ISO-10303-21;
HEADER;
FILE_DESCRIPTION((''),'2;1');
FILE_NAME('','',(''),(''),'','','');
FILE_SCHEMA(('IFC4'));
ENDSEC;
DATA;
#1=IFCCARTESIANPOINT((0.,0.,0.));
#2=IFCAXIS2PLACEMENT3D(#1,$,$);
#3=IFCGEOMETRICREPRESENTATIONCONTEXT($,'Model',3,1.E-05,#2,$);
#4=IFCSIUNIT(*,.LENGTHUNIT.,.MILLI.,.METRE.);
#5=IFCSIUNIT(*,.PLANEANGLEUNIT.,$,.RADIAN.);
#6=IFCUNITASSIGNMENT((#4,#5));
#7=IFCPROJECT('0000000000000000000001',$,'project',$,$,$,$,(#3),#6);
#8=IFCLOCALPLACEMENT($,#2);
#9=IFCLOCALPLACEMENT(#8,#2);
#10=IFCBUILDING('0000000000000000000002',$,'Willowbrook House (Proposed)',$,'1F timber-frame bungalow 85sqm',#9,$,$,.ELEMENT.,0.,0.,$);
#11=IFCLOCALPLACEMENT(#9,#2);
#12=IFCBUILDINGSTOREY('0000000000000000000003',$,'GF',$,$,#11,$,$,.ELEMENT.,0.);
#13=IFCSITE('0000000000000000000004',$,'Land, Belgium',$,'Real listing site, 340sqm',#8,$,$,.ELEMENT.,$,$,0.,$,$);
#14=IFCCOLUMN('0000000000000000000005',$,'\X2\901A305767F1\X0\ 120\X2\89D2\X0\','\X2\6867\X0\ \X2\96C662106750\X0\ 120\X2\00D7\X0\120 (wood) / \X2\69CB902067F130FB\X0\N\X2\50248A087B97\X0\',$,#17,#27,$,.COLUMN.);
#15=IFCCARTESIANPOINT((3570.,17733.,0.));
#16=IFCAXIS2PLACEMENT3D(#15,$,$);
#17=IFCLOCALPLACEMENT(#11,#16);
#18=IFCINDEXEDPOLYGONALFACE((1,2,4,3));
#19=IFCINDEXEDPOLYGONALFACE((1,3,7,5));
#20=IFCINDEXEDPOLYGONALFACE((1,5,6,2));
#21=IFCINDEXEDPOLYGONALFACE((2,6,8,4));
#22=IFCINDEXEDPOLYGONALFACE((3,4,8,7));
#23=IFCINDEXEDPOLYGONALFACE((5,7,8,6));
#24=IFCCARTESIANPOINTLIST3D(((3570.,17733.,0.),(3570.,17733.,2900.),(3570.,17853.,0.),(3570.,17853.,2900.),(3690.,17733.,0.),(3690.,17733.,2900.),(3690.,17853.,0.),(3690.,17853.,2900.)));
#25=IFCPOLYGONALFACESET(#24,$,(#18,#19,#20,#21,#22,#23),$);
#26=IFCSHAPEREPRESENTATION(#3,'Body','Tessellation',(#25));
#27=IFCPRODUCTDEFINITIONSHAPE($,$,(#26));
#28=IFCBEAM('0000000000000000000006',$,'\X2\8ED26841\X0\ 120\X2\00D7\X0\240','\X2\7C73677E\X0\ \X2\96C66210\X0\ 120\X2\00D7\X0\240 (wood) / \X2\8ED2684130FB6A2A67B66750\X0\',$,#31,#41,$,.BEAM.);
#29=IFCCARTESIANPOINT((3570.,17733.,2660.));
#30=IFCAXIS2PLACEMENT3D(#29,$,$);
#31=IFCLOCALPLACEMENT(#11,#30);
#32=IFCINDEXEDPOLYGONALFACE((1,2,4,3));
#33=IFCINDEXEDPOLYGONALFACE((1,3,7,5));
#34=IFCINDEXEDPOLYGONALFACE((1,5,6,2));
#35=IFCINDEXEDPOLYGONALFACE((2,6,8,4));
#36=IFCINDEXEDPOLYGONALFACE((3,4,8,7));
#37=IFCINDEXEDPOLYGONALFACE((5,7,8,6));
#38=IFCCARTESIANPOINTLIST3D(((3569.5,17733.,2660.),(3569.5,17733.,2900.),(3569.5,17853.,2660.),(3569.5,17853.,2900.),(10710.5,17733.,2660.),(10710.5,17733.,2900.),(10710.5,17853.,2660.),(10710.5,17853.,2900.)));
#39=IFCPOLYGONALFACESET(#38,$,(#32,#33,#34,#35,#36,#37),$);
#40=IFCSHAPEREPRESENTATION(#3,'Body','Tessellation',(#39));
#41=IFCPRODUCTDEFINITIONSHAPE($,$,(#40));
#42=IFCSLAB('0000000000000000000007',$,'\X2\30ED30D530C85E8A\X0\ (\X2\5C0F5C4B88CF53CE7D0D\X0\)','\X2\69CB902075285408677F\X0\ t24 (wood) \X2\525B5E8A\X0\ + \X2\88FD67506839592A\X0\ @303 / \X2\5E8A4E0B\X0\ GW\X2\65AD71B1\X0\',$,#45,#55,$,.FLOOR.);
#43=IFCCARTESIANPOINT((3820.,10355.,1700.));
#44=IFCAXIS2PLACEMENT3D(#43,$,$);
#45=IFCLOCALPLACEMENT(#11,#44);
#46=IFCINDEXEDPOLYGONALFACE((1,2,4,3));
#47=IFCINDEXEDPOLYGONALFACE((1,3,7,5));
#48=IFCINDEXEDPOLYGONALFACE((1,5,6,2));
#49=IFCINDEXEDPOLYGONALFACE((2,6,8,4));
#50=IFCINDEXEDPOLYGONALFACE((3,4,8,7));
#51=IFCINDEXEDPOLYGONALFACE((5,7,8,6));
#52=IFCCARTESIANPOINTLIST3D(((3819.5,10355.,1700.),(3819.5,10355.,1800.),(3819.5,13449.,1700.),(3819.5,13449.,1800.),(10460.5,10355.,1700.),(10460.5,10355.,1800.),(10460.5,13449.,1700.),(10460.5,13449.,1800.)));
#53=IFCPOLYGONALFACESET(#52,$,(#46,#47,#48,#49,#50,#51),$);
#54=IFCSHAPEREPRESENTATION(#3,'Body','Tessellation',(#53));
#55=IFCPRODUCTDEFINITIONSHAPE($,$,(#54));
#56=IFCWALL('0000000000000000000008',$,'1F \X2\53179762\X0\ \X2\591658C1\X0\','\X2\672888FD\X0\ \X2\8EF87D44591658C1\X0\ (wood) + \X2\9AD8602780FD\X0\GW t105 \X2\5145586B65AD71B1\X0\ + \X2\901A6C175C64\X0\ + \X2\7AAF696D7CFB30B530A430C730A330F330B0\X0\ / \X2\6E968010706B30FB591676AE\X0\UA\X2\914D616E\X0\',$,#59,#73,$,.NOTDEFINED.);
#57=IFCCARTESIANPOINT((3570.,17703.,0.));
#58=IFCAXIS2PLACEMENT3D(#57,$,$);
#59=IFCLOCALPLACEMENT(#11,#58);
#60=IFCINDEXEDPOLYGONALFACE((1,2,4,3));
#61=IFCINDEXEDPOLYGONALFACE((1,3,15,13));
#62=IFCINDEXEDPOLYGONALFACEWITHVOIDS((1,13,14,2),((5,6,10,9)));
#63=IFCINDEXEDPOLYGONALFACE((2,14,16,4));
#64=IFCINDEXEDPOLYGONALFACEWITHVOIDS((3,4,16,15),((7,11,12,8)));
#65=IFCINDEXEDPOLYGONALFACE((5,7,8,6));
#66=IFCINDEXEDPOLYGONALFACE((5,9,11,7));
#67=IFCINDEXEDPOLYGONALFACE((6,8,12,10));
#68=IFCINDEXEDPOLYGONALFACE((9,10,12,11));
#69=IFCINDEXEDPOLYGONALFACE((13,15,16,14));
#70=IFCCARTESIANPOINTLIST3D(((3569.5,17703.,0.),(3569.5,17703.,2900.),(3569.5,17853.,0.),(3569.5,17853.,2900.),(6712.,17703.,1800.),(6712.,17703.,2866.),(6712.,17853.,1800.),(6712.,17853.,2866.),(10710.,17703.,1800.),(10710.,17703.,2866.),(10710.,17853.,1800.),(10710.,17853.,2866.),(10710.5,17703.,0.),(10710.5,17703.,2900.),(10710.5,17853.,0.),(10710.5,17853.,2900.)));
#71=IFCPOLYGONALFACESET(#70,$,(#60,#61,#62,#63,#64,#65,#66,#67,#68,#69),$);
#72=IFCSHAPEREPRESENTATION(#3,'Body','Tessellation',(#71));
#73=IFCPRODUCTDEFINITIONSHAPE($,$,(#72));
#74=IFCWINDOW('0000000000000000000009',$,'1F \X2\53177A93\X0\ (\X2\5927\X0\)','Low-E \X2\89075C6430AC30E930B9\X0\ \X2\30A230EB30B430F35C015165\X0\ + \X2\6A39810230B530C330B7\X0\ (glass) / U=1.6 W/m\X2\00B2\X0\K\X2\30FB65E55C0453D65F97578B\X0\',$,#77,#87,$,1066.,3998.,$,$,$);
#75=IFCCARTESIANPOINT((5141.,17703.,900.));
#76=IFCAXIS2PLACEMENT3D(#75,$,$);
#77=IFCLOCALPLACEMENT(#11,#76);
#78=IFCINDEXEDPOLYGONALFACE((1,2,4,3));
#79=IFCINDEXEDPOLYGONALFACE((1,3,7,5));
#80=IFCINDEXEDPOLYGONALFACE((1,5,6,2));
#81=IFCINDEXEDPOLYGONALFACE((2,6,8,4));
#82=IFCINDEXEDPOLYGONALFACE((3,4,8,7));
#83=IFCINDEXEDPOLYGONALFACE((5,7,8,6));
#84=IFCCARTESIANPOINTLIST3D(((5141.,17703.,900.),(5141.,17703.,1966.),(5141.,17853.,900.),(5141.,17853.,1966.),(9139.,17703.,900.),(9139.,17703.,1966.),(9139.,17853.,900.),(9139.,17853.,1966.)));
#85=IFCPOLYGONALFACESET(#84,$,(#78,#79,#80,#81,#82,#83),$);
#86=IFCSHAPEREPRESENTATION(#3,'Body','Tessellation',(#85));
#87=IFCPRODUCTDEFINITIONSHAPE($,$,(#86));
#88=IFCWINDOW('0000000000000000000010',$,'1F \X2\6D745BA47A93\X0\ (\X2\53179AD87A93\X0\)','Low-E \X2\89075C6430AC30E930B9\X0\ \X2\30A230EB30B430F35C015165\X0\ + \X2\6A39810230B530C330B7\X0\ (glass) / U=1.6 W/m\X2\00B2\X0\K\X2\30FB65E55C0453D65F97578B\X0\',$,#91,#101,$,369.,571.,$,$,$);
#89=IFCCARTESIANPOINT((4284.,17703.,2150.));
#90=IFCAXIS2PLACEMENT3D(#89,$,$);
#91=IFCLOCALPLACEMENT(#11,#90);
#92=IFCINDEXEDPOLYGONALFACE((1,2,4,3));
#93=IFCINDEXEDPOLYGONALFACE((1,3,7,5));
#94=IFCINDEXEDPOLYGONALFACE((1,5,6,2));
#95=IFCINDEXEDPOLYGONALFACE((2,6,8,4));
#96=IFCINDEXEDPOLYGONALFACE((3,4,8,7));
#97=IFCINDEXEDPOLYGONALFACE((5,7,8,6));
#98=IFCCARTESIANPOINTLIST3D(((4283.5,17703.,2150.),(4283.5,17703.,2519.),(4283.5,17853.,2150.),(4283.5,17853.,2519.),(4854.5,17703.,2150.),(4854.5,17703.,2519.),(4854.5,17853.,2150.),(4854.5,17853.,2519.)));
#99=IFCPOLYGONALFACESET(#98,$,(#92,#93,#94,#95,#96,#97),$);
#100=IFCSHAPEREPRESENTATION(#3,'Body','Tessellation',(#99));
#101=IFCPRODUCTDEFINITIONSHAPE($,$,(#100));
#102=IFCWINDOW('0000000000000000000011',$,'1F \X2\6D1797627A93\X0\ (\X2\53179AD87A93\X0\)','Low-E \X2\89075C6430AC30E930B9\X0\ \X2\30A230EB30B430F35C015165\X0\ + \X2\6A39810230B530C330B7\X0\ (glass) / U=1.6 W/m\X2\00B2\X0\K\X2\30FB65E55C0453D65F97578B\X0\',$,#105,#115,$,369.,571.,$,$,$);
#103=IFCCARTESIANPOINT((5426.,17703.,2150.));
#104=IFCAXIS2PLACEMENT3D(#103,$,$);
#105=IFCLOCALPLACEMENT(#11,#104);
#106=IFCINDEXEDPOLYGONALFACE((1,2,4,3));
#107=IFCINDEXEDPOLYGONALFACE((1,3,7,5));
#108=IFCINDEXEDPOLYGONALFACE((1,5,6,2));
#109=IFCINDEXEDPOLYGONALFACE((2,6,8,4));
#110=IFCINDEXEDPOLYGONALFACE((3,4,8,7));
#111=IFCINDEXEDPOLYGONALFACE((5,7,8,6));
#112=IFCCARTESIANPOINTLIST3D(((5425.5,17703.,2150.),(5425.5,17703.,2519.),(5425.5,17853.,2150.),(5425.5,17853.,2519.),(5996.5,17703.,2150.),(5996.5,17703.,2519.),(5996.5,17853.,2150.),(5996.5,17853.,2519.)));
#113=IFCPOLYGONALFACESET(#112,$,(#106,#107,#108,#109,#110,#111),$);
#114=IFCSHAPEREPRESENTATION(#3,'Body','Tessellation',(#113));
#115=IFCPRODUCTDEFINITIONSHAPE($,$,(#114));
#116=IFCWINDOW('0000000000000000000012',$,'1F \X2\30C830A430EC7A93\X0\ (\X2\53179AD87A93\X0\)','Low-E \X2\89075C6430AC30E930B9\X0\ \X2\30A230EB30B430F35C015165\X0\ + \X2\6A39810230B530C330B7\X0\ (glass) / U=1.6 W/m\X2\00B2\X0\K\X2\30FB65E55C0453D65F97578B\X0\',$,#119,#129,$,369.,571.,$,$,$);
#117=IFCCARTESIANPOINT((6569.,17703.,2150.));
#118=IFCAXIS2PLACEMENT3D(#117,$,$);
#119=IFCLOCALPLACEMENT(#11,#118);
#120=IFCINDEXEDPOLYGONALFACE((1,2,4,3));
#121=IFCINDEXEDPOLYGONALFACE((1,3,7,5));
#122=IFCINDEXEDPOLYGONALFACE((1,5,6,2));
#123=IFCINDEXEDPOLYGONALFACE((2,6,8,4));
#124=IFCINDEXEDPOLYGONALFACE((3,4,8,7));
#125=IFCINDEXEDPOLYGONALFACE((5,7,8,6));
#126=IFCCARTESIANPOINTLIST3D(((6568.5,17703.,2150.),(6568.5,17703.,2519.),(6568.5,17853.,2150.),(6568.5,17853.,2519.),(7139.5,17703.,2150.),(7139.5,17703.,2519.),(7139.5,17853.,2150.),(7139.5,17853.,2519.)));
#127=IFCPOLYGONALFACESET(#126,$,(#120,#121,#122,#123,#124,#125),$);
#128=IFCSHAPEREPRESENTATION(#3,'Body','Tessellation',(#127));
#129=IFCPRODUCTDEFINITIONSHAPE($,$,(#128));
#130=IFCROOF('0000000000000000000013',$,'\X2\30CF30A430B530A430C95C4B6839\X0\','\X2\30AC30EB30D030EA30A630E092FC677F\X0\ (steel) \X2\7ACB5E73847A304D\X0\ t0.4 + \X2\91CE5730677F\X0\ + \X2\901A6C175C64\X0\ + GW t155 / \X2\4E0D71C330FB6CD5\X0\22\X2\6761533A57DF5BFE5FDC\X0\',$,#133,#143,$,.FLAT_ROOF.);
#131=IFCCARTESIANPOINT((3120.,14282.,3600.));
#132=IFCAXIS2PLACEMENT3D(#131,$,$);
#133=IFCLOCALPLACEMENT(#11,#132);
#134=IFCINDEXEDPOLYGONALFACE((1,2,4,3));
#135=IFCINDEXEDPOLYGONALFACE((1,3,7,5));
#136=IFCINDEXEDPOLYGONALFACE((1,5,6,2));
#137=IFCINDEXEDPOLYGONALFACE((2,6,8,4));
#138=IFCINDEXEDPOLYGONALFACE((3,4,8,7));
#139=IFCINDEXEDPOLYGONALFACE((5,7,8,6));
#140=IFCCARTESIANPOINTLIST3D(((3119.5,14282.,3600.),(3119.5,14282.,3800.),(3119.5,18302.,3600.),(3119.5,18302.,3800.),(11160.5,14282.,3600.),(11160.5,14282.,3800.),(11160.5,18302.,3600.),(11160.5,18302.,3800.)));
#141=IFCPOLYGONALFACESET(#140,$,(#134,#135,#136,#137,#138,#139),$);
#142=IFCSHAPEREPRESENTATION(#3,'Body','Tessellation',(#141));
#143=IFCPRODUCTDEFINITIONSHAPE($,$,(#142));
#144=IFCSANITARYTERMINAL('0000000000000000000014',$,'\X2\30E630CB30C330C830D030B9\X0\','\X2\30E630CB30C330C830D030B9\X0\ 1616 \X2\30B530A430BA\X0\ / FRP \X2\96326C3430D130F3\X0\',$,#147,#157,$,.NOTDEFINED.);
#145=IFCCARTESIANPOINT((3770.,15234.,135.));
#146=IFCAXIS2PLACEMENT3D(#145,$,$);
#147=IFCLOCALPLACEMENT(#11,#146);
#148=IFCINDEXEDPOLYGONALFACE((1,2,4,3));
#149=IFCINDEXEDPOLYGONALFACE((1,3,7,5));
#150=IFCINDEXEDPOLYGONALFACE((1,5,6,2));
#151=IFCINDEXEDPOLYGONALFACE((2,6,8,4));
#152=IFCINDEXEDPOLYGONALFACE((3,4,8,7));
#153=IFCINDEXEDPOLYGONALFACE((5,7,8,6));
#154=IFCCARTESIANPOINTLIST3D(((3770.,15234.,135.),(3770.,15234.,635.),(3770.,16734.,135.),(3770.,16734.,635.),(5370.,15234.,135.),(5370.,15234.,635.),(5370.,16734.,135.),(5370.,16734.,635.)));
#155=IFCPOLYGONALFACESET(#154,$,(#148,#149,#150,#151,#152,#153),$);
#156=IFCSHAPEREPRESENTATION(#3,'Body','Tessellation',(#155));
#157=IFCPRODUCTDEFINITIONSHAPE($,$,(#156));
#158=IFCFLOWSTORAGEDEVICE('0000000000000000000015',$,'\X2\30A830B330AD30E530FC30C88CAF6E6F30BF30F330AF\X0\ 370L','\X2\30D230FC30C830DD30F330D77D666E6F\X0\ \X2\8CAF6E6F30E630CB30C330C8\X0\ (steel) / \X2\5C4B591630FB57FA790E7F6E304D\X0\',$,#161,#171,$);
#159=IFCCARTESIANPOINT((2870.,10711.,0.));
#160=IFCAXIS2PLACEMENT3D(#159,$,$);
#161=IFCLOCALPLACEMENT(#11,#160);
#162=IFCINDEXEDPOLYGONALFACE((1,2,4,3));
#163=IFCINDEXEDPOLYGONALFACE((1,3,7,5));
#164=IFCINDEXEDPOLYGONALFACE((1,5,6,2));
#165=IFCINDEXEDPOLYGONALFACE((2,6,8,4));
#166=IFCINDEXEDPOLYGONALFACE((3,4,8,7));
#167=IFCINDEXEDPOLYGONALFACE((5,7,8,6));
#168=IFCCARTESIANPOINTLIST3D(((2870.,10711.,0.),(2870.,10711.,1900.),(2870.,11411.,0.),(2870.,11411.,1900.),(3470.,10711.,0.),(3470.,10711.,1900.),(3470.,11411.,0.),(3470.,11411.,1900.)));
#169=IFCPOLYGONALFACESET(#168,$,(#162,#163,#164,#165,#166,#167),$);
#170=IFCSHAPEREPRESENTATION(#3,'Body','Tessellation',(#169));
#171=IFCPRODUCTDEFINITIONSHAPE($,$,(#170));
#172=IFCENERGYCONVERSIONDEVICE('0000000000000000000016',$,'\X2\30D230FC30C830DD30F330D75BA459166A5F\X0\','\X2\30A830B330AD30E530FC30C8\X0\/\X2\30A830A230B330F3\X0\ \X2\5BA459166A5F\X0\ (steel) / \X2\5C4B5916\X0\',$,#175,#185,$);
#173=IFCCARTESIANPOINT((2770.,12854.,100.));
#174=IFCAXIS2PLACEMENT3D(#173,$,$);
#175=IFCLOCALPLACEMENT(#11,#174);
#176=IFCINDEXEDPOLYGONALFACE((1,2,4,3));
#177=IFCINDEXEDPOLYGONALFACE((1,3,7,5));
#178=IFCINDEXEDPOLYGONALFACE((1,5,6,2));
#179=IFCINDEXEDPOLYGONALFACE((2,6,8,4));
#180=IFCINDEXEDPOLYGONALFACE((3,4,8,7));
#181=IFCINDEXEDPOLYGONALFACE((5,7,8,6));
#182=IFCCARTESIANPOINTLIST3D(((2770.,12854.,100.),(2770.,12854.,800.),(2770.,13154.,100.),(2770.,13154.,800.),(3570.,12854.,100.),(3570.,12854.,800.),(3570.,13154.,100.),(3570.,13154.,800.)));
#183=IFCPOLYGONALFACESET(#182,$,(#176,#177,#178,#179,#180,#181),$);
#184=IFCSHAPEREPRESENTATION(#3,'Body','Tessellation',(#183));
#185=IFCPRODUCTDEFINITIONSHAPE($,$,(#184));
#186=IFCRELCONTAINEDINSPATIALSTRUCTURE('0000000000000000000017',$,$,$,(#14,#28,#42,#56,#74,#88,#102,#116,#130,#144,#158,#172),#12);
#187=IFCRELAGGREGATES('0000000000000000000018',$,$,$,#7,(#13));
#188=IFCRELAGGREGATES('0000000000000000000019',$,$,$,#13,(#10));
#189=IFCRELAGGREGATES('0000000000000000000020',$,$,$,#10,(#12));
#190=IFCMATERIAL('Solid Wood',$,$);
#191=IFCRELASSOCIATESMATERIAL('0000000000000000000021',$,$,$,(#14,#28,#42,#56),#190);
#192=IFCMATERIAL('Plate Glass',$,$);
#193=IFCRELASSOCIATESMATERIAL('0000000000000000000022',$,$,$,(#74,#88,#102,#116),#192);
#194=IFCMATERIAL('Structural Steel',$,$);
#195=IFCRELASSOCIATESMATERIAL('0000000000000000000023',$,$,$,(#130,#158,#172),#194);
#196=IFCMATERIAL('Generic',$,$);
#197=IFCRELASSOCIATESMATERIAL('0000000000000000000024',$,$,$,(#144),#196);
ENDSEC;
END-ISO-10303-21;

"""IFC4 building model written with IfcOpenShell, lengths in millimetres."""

from ifc_helpers import new_model, si_unit, frame, frame_2d, origin, place, context, project, spatial, rectangle, extrude, material, element, fill, save


model = new_model("IFC4")

# Units and contexts
model_context = context("Model", 3, precision=1e-05, world=origin())
ifc_project = project(units=[si_unit("LENGTHUNIT", "METRE", prefix="MILLI"), si_unit("PLANEANGLEUNIT", "RADIAN")], contexts=[model_context])

# Site, building, storey
site_placement = place(None, origin())
site = spatial("IfcSite", under=ifc_project, at=site_placement, Name="Land, Belgium", ObjectType="Real listing site, 340sqm", CompositionType="ELEMENT", RefElevation=0.0)
building_placement = place(site_placement, origin())
building = spatial("IfcBuilding", under=site, at=building_placement, Name="Willowbrook House (Proposed)", ObjectType="1F timber-frame bungalow 85sqm", CompositionType="ELEMENT", ElevationOfRefHeight=0.0, ElevationOfTerrain=0.0)
storey_placement = place(building_placement, origin())
storey = spatial("IfcBuildingStorey", under=building, at=storey_placement, Name="GF", CompositionType="ELEMENT", Elevation=0.0)

# Column
ifc_material_1 = material(Name="Solid Wood")
column_1_placement = place(storey_placement, frame((3570.0, 17733.0, 0.0)))
element("IfcColumn", 1, at=column_1_placement, inside=storey, material=ifc_material_1, Name="通し柱 120角", Description="桧 集成材 120×120 (wood) / 構造柱・N値計算", PredefinedType="COLUMN", context=model_context, shape_type="SweptSolid", body=[
    extrude(rectangle(XDim=120.0, YDim=120.0, at=frame_2d((60.0, 60.0))), frame((3570.0, 17733.0, 0.0)), (0.0, 0.0, 1.0), 2900.0),
])

# Beam
beam_1_placement = place(storey_placement, frame((3570.0, 17733.0, 2660.0)))
element("IfcBeam", 2, at=beam_1_placement, inside=storey, material=ifc_material_1, Name="軒桁 120×240", Description="米松 集成 120×240 (wood) / 軒桁・横架材", PredefinedType="BEAM", context=model_context, shape_type="SweptSolid", body=[
    extrude(rectangle(XDim=7141.0, YDim=120.0, at=frame_2d((3570.0, 60.0))), frame((3570.0, 17733.0, 2660.0)), (0.0, 0.0, 1.0), 240.0),
])

# Slab
slab_placement = place(storey_placement, frame((3820.0, 10355.0, 1700.0)))
element("IfcSlab", 3, at=slab_placement, inside=storey, material=ifc_material_1, Name="ロフト床 (小屋裏収納)", Description="構造用合板 t24 (wood) 剛床 + 製材根太 @303 / 床下 GW断熱", PredefinedType="FLOOR", context=model_context, shape_type="SweptSolid", body=[
    extrude(rectangle(XDim=6641.0, YDim=3094.0, at=frame_2d((3320.0, 1547.0))), frame((3820.0, 10355.0, 1700.0)), (0.0, 0.0, 1.0), 100.0),
])

# Wall, openings, windows
wall_1_placement = place(storey_placement, frame((3570.0, 17703.0, 0.0)))
wall_1 = element("IfcWall", 4, at=wall_1_placement, inside=storey, material=ifc_material_1, Name="1F 北面 外壁", Description="木製 軸組外壁 (wood) + 高性能GW t105 充填断熱 + 通気層 + 窯業系サイディング / 準耐火・外皮UA配慮", PredefinedType="NOTDEFINED", context=model_context, shape_type="SweptSolid", body=[
    extrude(rectangle(XDim=7141.0, YDim=150.0, at=frame_2d((3570.0, 75.0))), frame((3570.0, 17703.0, 0.0)), (0.0, 0.0, 1.0), 2900.0),
])
opening_1_placement = place(storey_placement, frame((5141.0, 17703.0, 900.0)))
opening_1 = element("IfcOpeningElement", 5, at=opening_1_placement, cuts=wall_1, PredefinedType="NOTDEFINED", context=model_context, shape_type="SweptSolid", body=[
    extrude(rectangle(XDim=3998.0, YDim=150.0, at=frame_2d((1999.0, 75.0))), frame((5141.0, 17703.0, 900.0)), (0.0, 0.0, 1.0), 1066.0),
])
opening_2_placement = place(storey_placement, frame((4284.0, 17703.0, 2150.0)))
opening_2 = element("IfcOpeningElement", 6, at=opening_2_placement, cuts=wall_1, PredefinedType="NOTDEFINED", context=model_context, shape_type="SweptSolid", body=[
    extrude(rectangle(XDim=571.0, YDim=150.0, at=frame_2d((285.0, 75.0))), frame((4284.0, 17703.0, 2150.0)), (0.0, 0.0, 1.0), 369.0),
])
opening_3_placement = place(storey_placement, frame((5426.0, 17703.0, 2150.0)))
opening_3 = element("IfcOpeningElement", 7, at=opening_3_placement, cuts=wall_1, PredefinedType="NOTDEFINED", context=model_context, shape_type="SweptSolid", body=[
    extrude(rectangle(XDim=571.0, YDim=150.0, at=frame_2d((285.0, 75.0))), frame((5426.0, 17703.0, 2150.0)), (0.0, 0.0, 1.0), 369.0),
])
opening_4_placement = place(storey_placement, frame((6569.0, 17703.0, 2150.0)))
opening_4 = element("IfcOpeningElement", 8, at=opening_4_placement, cuts=wall_1, PredefinedType="NOTDEFINED", context=model_context, shape_type="SweptSolid", body=[
    extrude(rectangle(XDim=571.0, YDim=150.0, at=frame_2d((285.0, 75.0))), frame((6569.0, 17703.0, 2150.0)), (0.0, 0.0, 1.0), 369.0),
])
ifc_material_2 = material(Name="Plate Glass")
window_1_placement = place(storey_placement, frame((5141.0, 17703.0, 900.0)))
window_1 = element("IfcWindow", 9, at=window_1_placement, inside=storey, material=ifc_material_2, Name="1F 北窓 (大)", Description="Low-E 複層ガラス アルゴン封入 + 樹脂サッシ (glass) / U=1.6 W/m²K・日射取得型", OverallHeight=1066.0, OverallWidth=3998.0, context=model_context, shape_type="SweptSolid", body=[
    extrude(rectangle(XDim=3998.0, YDim=150.0, at=frame_2d((1999.0, 75.0))), frame((5141.0, 17703.0, 900.0)), (0.0, 0.0, 1.0), 1066.0),
])
fill(opening_1, window_1)
window_2_placement = place(storey_placement, frame((4284.0, 17703.0, 2150.0)))
window_2 = element("IfcWindow", 10, at=window_2_placement, inside=storey, material=ifc_material_2, Name="1F 浴室窓 (北高窓)", Description="Low-E 複層ガラス アルゴン封入 + 樹脂サッシ (glass) / U=1.6 W/m²K・日射取得型", OverallHeight=369.0, OverallWidth=571.0, context=model_context, shape_type="SweptSolid", body=[
    extrude(rectangle(XDim=571.0, YDim=150.0, at=frame_2d((285.0, 75.0))), frame((4284.0, 17703.0, 2150.0)), (0.0, 0.0, 1.0), 369.0),
])
fill(opening_2, window_2)
window_3_placement = place(storey_placement, frame((5426.0, 17703.0, 2150.0)))
window_3 = element("IfcWindow", 11, at=window_3_placement, inside=storey, material=ifc_material_2, Name="1F 洗面窓 (北高窓)", Description="Low-E 複層ガラス アルゴン封入 + 樹脂サッシ (glass) / U=1.6 W/m²K・日射取得型", OverallHeight=369.0, OverallWidth=571.0, context=model_context, shape_type="SweptSolid", body=[
    extrude(rectangle(XDim=571.0, YDim=150.0, at=frame_2d((285.0, 75.0))), frame((5426.0, 17703.0, 2150.0)), (0.0, 0.0, 1.0), 369.0),
])
fill(opening_3, window_3)
window_4_placement = place(storey_placement, frame((6569.0, 17703.0, 2150.0)))
window_4 = element("IfcWindow", 12, at=window_4_placement, inside=storey, material=ifc_material_2, Name="1F トイレ窓 (北高窓)", Description="Low-E 複層ガラス アルゴン封入 + 樹脂サッシ (glass) / U=1.6 W/m²K・日射取得型", OverallHeight=369.0, OverallWidth=571.0, context=model_context, shape_type="SweptSolid", body=[
    extrude(rectangle(XDim=571.0, YDim=150.0, at=frame_2d((285.0, 75.0))), frame((6569.0, 17703.0, 2150.0)), (0.0, 0.0, 1.0), 369.0),
])
fill(opening_4, window_4)

# Roof
ifc_material_3 = material(Name="Structural Steel")
roof_placement = place(storey_placement, frame((3120.0, 14282.0, 3600.0)))
element("IfcRoof", 13, at=roof_placement, inside=storey, material=ifc_material_3, Name="ハイサイド屋根", Description="ガルバリウム鋼板 (steel) 立平葺き t0.4 + 野地板 + 通気層 + GW t155 / 不燃・法22条区域対応", PredefinedType="FLAT_ROOF", context=model_context, shape_type="SweptSolid", body=[
    extrude(rectangle(XDim=8041.0, YDim=4020.0, at=frame_2d((4020.0, 2010.0))), frame((3120.0, 14282.0, 3600.0)), (0.0, 0.0, 1.0), 200.0),
])

# Sanitary terminal
ifc_material_4 = material(Name="Generic")
sanitary_terminal_placement = place(storey_placement, frame((3770.0, 15234.0, 135.0)))
element("IfcSanitaryTerminal", 14, at=sanitary_terminal_placement, inside=storey, material=ifc_material_4, Name="ユニットバス", Description="ユニットバス 1616 サイズ / FRP 防水パン", PredefinedType="NOTDEFINED", context=model_context, shape_type="SweptSolid", body=[
    extrude(rectangle(XDim=1600.0, YDim=1500.0, at=frame_2d((800.0, 750.0))), frame((3770.0, 15234.0, 135.0)), (0.0, 0.0, 1.0), 500.0),
])

# Flow storage device
flow_storage_device_placement = place(storey_placement, frame((2870.0, 10711.0, 0.0)))
element("IfcFlowStorageDevice", 15, at=flow_storage_device_placement, inside=storey, material=ifc_material_3, Name="エコキュート貯湯タンク 370L", Description="ヒートポンプ給湯 貯湯ユニット (steel) / 屋外・基礎置き", context=model_context, shape_type="SweptSolid", body=[
    extrude(rectangle(XDim=600.0, YDim=700.0, at=frame_2d((300.0, 350.0))), frame((2870.0, 10711.0, 0.0)), (0.0, 0.0, 1.0), 1900.0),
])

# Energy conversion device
energy_conversion_device_placement = place(storey_placement, frame((2770.0, 12854.0, 100.0)))
element("IfcEnergyConversionDevice", 16, at=energy_conversion_device_placement, inside=storey, material=ifc_material_3, Name="ヒートポンプ室外機", Description="エコキュート/エアコン 室外機 (steel) / 屋外", context=model_context, shape_type="SweptSolid", body=[
    extrude(rectangle(XDim=800.0, YDim=300.0, at=frame_2d((400.0, 150.0))), frame((2770.0, 12854.0, 100.0)), (0.0, 0.0, 1.0), 700.0),
])

save(model, "model.ifc")
